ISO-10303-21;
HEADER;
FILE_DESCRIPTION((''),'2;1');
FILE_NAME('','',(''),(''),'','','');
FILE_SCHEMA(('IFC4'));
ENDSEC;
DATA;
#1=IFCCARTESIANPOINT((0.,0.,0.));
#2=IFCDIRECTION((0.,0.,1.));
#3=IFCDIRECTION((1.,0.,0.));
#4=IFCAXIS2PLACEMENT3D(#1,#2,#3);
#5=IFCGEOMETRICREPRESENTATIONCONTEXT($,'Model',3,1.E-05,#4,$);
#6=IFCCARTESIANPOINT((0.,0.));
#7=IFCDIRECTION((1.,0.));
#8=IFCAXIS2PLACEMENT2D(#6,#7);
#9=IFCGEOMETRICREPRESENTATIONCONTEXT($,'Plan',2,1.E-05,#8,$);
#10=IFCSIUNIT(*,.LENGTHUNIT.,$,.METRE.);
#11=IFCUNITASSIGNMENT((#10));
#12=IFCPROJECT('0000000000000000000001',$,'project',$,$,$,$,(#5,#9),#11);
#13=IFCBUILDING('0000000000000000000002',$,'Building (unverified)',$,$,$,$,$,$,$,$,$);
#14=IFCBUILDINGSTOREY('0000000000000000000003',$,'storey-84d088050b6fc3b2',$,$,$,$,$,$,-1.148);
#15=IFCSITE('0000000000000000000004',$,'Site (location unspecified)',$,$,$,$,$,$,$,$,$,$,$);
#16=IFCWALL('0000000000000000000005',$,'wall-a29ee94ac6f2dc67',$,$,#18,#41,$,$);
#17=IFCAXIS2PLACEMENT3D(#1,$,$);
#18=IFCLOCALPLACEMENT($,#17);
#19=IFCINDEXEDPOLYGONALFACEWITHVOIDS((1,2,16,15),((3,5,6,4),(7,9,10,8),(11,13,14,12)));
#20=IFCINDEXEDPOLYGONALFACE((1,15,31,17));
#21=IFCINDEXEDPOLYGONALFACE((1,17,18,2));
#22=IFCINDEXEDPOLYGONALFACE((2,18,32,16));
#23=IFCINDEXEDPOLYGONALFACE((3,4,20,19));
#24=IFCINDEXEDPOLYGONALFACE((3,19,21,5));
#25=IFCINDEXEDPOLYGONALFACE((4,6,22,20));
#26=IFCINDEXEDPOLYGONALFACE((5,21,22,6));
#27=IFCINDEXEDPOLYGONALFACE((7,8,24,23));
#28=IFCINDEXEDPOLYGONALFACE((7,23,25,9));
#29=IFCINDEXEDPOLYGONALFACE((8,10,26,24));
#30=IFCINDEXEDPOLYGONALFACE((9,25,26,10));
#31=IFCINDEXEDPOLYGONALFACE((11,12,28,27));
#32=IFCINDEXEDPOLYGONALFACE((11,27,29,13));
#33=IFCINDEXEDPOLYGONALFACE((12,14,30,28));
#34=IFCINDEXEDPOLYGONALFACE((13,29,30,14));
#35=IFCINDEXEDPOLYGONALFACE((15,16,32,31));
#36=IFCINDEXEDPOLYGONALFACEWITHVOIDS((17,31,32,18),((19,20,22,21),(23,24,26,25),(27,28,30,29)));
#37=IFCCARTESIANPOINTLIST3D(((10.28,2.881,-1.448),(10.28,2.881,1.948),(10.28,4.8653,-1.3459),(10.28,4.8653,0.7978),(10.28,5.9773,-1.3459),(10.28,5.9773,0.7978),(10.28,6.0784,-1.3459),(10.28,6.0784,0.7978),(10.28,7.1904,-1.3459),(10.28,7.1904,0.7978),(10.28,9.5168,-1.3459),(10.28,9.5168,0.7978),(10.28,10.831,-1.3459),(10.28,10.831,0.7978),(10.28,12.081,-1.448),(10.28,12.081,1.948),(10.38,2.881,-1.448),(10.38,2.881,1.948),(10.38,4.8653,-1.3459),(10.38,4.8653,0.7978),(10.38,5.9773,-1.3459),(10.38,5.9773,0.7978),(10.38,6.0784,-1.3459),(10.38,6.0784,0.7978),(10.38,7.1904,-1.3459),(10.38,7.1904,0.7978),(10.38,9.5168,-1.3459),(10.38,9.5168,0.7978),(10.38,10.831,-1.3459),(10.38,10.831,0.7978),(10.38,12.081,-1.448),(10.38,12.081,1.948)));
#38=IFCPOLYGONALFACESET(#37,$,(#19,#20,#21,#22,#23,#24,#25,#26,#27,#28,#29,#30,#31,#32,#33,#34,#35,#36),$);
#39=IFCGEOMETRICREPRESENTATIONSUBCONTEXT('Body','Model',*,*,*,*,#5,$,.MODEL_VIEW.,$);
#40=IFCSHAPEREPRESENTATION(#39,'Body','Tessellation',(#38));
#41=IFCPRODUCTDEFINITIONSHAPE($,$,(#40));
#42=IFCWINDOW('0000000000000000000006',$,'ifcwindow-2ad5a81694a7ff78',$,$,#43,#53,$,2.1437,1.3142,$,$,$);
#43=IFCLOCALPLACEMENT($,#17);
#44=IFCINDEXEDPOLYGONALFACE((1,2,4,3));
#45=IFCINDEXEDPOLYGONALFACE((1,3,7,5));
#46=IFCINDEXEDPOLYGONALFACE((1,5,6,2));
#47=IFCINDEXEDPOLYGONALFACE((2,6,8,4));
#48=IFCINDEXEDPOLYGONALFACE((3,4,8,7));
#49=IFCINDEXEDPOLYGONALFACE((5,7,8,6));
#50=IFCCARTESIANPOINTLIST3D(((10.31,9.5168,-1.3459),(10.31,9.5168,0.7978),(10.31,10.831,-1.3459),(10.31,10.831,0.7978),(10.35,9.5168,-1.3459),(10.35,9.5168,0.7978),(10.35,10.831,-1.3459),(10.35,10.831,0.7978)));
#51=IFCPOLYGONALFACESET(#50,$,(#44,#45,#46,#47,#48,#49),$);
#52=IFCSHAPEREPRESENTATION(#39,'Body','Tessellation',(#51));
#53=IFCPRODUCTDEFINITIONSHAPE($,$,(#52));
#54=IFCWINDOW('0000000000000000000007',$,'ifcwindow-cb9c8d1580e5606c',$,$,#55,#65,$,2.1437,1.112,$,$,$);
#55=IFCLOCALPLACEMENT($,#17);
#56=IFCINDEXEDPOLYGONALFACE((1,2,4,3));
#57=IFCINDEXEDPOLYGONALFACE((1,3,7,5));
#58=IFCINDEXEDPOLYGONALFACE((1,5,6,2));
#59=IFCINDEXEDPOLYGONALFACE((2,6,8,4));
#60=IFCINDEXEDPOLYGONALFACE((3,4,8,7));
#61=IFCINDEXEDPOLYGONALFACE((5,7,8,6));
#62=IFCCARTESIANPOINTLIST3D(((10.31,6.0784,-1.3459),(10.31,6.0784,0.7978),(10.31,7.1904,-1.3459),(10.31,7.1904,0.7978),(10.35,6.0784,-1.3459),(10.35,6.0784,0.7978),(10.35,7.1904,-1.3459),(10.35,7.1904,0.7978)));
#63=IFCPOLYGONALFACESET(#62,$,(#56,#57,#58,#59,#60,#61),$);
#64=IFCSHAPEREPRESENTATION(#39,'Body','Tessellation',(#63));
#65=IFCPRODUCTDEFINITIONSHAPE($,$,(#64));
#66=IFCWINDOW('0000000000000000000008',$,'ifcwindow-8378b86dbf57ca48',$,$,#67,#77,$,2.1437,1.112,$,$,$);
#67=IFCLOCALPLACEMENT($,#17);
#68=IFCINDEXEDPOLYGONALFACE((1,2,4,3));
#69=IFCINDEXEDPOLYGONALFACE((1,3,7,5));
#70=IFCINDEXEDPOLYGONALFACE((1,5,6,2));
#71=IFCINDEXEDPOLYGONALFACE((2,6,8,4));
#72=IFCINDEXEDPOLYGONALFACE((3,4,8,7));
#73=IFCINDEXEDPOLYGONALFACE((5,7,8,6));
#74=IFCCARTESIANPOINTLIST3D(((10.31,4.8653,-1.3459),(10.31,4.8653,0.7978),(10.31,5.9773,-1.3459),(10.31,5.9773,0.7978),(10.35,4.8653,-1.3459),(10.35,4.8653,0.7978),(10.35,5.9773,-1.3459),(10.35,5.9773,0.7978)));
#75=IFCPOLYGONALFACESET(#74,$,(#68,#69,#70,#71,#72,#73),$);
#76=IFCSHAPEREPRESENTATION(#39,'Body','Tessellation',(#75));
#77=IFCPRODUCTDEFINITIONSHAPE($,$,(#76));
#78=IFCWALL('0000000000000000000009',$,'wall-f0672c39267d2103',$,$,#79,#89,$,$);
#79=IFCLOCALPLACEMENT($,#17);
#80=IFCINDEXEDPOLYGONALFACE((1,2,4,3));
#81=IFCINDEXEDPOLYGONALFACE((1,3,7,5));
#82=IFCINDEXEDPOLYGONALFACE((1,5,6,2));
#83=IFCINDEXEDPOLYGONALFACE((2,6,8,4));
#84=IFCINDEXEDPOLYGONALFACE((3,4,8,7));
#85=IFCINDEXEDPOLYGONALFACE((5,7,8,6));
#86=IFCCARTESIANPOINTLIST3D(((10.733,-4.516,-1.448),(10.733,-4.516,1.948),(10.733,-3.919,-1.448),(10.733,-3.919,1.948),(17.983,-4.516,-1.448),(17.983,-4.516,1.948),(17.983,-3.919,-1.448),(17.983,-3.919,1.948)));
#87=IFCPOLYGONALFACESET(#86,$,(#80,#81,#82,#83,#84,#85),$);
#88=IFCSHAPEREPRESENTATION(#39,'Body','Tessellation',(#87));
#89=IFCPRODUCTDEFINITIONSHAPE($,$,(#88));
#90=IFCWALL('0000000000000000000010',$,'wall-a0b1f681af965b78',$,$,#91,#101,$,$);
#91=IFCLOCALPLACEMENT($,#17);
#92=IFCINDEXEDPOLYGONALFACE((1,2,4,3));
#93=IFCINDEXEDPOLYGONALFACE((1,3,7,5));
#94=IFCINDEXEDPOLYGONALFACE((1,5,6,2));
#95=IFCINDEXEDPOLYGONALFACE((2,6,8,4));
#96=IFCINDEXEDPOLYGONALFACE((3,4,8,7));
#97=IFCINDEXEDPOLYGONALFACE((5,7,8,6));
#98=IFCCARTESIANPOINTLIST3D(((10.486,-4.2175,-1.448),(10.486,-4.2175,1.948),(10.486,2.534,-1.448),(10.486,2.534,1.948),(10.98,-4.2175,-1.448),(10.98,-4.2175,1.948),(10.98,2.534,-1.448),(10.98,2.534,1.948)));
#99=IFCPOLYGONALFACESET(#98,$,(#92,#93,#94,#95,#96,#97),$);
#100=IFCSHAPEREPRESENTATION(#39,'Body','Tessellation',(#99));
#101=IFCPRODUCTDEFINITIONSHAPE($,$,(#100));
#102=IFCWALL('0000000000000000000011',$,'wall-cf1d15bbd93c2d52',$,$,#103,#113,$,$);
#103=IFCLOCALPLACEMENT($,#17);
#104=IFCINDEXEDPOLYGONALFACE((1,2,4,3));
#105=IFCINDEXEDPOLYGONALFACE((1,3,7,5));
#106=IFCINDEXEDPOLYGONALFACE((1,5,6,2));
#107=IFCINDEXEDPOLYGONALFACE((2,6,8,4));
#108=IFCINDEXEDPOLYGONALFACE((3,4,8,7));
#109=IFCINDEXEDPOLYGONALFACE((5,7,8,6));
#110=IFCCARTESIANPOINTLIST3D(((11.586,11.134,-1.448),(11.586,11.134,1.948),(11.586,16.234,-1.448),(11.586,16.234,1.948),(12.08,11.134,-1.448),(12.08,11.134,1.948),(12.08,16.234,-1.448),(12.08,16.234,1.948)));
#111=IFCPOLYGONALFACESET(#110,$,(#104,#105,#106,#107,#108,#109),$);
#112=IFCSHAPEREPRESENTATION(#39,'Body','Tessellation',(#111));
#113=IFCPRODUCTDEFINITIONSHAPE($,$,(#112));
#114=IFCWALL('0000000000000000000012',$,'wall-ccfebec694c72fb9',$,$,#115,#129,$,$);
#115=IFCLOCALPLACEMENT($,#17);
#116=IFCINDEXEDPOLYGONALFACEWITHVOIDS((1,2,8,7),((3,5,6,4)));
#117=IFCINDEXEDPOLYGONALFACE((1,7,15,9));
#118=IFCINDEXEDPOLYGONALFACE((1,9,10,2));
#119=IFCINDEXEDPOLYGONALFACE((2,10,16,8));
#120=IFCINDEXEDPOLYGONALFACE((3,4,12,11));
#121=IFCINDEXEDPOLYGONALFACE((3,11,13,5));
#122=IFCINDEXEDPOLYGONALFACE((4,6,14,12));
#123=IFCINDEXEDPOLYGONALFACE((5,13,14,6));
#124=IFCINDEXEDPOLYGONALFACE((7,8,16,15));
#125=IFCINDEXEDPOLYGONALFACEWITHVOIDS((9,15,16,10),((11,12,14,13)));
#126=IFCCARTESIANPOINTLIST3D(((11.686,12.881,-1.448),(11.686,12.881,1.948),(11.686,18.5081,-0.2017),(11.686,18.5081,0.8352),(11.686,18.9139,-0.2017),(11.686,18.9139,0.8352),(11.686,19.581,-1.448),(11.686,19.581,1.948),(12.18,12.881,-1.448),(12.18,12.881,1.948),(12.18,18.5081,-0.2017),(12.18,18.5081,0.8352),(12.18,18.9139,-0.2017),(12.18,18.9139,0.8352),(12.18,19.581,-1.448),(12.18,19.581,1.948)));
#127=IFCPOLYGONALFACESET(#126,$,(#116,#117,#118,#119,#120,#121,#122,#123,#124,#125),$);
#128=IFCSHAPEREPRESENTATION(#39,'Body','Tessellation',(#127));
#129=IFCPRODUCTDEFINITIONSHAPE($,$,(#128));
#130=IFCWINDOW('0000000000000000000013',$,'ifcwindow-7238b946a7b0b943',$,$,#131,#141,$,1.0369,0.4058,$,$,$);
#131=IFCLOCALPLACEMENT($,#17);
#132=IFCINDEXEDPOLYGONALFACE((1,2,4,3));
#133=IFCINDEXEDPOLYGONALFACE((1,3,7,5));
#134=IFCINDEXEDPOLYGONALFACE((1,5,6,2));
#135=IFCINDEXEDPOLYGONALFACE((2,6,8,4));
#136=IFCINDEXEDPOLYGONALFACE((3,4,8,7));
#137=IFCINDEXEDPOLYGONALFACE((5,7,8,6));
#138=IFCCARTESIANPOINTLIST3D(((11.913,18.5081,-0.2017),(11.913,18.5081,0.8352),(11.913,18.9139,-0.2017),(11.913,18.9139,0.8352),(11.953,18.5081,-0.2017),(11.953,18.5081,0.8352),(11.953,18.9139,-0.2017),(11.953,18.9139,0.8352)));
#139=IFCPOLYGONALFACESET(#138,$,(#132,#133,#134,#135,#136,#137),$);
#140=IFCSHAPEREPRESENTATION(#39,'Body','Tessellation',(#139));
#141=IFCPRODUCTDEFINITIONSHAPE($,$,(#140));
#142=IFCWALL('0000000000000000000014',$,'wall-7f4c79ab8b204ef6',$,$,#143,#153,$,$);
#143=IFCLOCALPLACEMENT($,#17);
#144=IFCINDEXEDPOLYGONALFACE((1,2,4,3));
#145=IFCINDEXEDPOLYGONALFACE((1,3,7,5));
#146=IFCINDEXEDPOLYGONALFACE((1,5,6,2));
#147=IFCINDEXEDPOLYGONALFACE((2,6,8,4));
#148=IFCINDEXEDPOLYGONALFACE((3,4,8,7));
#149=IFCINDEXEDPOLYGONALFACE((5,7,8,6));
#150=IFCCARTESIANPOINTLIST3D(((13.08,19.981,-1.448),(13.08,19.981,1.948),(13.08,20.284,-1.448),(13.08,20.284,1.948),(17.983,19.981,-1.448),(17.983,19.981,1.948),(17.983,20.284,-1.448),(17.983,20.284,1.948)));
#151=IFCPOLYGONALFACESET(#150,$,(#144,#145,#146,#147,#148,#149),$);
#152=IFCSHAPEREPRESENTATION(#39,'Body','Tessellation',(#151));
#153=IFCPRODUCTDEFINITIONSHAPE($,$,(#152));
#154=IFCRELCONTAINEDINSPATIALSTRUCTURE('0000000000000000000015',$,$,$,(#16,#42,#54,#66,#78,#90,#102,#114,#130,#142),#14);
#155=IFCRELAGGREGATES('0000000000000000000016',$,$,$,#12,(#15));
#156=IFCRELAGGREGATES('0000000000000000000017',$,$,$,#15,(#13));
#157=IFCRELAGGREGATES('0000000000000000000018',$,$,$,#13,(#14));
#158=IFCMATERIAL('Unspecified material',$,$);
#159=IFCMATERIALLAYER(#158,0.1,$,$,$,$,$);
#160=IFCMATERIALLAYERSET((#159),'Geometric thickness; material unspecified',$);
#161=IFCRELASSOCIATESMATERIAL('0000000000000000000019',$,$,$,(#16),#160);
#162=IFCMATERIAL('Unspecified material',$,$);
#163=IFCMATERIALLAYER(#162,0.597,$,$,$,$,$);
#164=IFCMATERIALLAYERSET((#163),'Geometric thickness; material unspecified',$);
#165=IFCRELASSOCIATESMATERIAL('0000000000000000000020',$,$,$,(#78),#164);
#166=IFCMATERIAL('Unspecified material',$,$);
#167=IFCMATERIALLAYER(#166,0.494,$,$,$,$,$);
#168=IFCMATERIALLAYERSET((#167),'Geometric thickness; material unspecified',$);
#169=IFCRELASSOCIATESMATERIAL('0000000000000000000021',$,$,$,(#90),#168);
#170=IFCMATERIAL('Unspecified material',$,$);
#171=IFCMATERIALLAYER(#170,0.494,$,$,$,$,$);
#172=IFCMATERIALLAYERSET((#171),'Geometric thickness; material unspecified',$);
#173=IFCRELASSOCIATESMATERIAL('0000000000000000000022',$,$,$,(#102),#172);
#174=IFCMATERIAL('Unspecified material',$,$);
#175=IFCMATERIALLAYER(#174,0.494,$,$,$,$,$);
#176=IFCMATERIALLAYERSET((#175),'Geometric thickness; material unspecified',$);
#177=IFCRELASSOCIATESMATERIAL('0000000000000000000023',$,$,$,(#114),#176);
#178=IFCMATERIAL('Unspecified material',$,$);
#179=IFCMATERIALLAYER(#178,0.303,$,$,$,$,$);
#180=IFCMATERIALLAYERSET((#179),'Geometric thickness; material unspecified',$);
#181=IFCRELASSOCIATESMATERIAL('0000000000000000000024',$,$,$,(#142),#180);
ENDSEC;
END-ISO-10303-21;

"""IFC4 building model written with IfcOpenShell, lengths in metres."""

from ifc_helpers import new_model, si_unit, frame, origin_with_axes, origin_2d_with_axis, place, context, subcontext, project, spatial, indexed_curve, outline, extrude, material, layer, layer_set, layer_usage, element, fill, save


model = new_model("IFC4")

# Units and contexts
model_context = context("Model", 3, precision=1e-05, world=origin_with_axes())
plan_context = context("Plan", 2, precision=1e-05, world=origin_2d_with_axis())
body_context = subcontext(model_context, "Body", "Model", "MODEL_VIEW")
ifc_project = project(units=[si_unit("LENGTHUNIT", "METRE")], contexts=[model_context, plan_context])

# Site, building, storey
site = spatial("IfcSite", under=ifc_project, Name="Site (location unspecified)")
building = spatial("IfcBuilding", under=site, Name="Building (unverified)")
storey = spatial("IfcBuildingStorey", under=building, Name="storey-84d088050b6fc3b2", Elevation=-1.148)

# Wall, openings, windows
ifc_material_1 = material(Name="Unspecified material")
ifc_layer_1 = layer(ifc_material_1, 0.1)
ifc_layer_set_1 = layer_set([ifc_layer_1], Name="Geometric thickness; material unspecified")
ifc_layer_usage_1 = layer_usage(ifc_layer_set_1, "AXIS2", "POSITIVE", -0.05)
wall_1_placement = place(None, frame((10.33, 12.081, -1.448), z_axis=(0.0, 0.0, 1.0), x_axis=(0.0, -1.0, 0.0)))
wall_1 = element("IfcWall", 1, at=wall_1_placement, inside=storey, material=ifc_layer_usage_1, Name="wall-a29ee94ac6f2dc67", context=body_context, shape_type="SweptSolid", body=[
    extrude(outline(indexed_curve([(0.0, 0.0), (0.0, 0.1), (9.2, 0.1), (9.2, 0.0), (0.0, 0.0)], self_intersect=False)), frame((0.0, -0.05, 0.0), z_axis=(0.0, 0.0, 1.0), x_axis=(1.0, 0.0, 0.0)), (0.0, 0.0, 1.0), 3.396),
])
opening_1_placement = place(wall_1_placement, frame((1.25, -0.06, 0.1021), z_axis=(0.0, 0.0, 1.0), x_axis=(1.0, 0.0, 0.0)))
opening_1 = element("IfcOpeningElement", 2, at=opening_1_placement, cuts=wall_1, context=body_context, shape_type="SweptSolid", body=[
    extrude(outline(indexed_curve([(0.0, 0.0), (0.0, 0.12), (1.3142, 0.12), (1.3142, 0.0), (0.0, 0.0)], self_intersect=False)), origin_with_axes(), (0.0, 0.0, 1.0), 2.1437),
])
opening_2_placement = place(wall_1_placement, frame((4.8906, -0.06, 0.1021), z_axis=(0.0, 0.0, 1.0), x_axis=(1.0, 0.0, 0.0)))
opening_2 = element("IfcOpeningElement", 3, at=opening_2_placement, cuts=wall_1, context=body_context, shape_type="SweptSolid", body=[
    extrude(outline(indexed_curve([(0.0, 0.0), (0.0, 0.12), (1.112, 0.12), (1.112, 0.0), (0.0, 0.0)], self_intersect=False)), origin_with_axes(), (0.0, 0.0, 1.0), 2.1437),
])
opening_3_placement = place(wall_1_placement, frame((6.1037, -0.06, 0.1021), z_axis=(0.0, 0.0, 1.0), x_axis=(1.0, 0.0, 0.0)))
opening_3 = element("IfcOpeningElement", 4, at=opening_3_placement, cuts=wall_1, context=body_context, shape_type="SweptSolid", body=[
    extrude(outline(indexed_curve([(0.0, 0.0), (0.0, 0.12), (1.112, 0.12), (1.112, 0.0), (0.0, 0.0)], self_intersect=False)), origin_with_axes(), (0.0, 0.0, 1.0), 2.1437),
])
window_1_placement = place(None, frame((10.31, 10.831, -1.3459), z_axis=(0.0, 0.0, 1.0), x_axis=(0.0, -1.0, 0.0)))
window_1 = element("IfcWindow", 5, at=window_1_placement, inside=storey, Name="ifcwindow-2ad5a81694a7ff78", OverallHeight=2.1437, OverallWidth=1.3142, context=body_context, shape_type="SweptSolid", body=[
    extrude(outline(indexed_curve([(0.0, 0.0), (0.0, 0.04), (1.3142, 0.04), (1.3142, 0.0), (0.0, 0.0)], self_intersect=False)), origin_with_axes(), (0.0, 0.0, 1.0), 2.1437),
])
fill(opening_1, window_1)
window_2_placement = place(None, frame((10.31, 7.1904, -1.3459), z_axis=(0.0, 0.0, 1.0), x_axis=(0.0, -1.0, 0.0)))
window_2 = element("IfcWindow", 6, at=window_2_placement, inside=storey, Name="ifcwindow-cb9c8d1580e5606c", OverallHeight=2.1437, OverallWidth=1.112, context=body_context, shape_type="SweptSolid", body=[
    extrude(outline(indexed_curve([(0.0, 0.0), (0.0, 0.04), (1.112, 0.04), (1.112, 0.0), (0.0, 0.0)], self_intersect=False)), origin_with_axes(), (0.0, 0.0, 1.0), 2.1437),
])
fill(opening_2, window_2)
window_3_placement = place(None, frame((10.31, 5.9773, -1.3459), z_axis=(0.0, 0.0, 1.0), x_axis=(0.0, -1.0, 0.0)))
window_3 = element("IfcWindow", 7, at=window_3_placement, inside=storey, Name="ifcwindow-8378b86dbf57ca48", OverallHeight=2.1437, OverallWidth=1.112, context=body_context, shape_type="SweptSolid", body=[
    extrude(outline(indexed_curve([(0.0, 0.0), (0.0, 0.04), (1.112, 0.04), (1.112, 0.0), (0.0, 0.0)], self_intersect=False)), origin_with_axes(), (0.0, 0.0, 1.0), 2.1437),
])
fill(opening_3, window_3)

# Walls
ifc_material_2 = material(Name="Unspecified material")
ifc_layer_2 = layer(ifc_material_2, 0.597)
ifc_layer_set_2 = layer_set([ifc_layer_2], Name="Geometric thickness; material unspecified")
ifc_layer_usage_2 = layer_usage(ifc_layer_set_2, "AXIS2", "POSITIVE", -0.2985)
wall_2_placement = place(None, frame((17.983, -4.2175, -1.448), z_axis=(0.0, 0.0, 1.0), x_axis=(-1.0, 0.0, 0.0)))
element("IfcWall", 8, at=wall_2_placement, inside=storey, material=ifc_layer_usage_2, Name="wall-f0672c39267d2103", context=body_context, shape_type="SweptSolid", body=[
    extrude(outline(indexed_curve([(0.0, 0.0), (0.0, 0.597), (7.25, 0.597), (7.25, 0.0), (0.0, 0.0)], self_intersect=False)), frame((0.0, -0.2985, 0.0), z_axis=(0.0, 0.0, 1.0), x_axis=(1.0, 0.0, 0.0)), (0.0, 0.0, 1.0), 3.396),
])
ifc_material_3 = material(Name="Unspecified material")
ifc_layer_3 = layer(ifc_material_3, 0.494)
ifc_layer_set_3 = layer_set([ifc_layer_3], Name="Geometric thickness; material unspecified")
ifc_layer_usage_3 = layer_usage(ifc_layer_set_3, "AXIS2", "POSITIVE", -0.247)
wall_3_placement = place(None, frame((10.733, -4.2175, -1.448), z_axis=(0.0, 0.0, 1.0), x_axis=(0.0, 1.0, 0.0)))
element("IfcWall", 9, at=wall_3_placement, inside=storey, material=ifc_layer_usage_3, Name="wall-a0b1f681af965b78", context=body_context, shape_type="SweptSolid", body=[
    extrude(outline(indexed_curve([(0.0, 0.0), (0.0, 0.494), (6.7515, 0.494), (6.7515, 0.0), (0.0, 0.0)], self_intersect=False)), frame((0.0, -0.247, 0.0), z_axis=(0.0, 0.0, 1.0), x_axis=(1.0, 0.0, 0.0)), (0.0, 0.0, 1.0), 3.396),
])
ifc_material_4 = material(Name="Unspecified material")
ifc_layer_4 = layer(ifc_material_4, 0.494)
ifc_layer_set_4 = layer_set([ifc_layer_4], Name="Geometric thickness; material unspecified")
ifc_layer_usage_4 = layer_usage(ifc_layer_set_4, "AXIS2", "POSITIVE", -0.247)
wall_4_placement = place(None, frame((11.833, 11.134, -1.448), z_axis=(0.0, 0.0, 1.0), x_axis=(0.0, 1.0, 0.0)))
element("IfcWall", 10, at=wall_4_placement, inside=storey, material=ifc_layer_usage_4, Name="wall-cf1d15bbd93c2d52", context=body_context, shape_type="SweptSolid", body=[
    extrude(outline(indexed_curve([(0.0, 0.0), (0.0, 0.494), (5.1, 0.494), (5.1, 0.0), (0.0, 0.0)], self_intersect=False)), frame((0.0, -0.247, 0.0), z_axis=(0.0, 0.0, 1.0), x_axis=(1.0, 0.0, 0.0)), (0.0, 0.0, 1.0), 3.396),
])

# Wall, opening, window
ifc_material_5 = material(Name="Unspecified material")
ifc_layer_5 = layer(ifc_material_5, 0.494)
ifc_layer_set_5 = layer_set([ifc_layer_5], Name="Geometric thickness; material unspecified")
ifc_layer_usage_5 = layer_usage(ifc_layer_set_5, "AXIS2", "POSITIVE", -0.247)
wall_5_placement = place(None, frame((11.933, 12.881, -1.448), z_axis=(0.0, 0.0, 1.0), x_axis=(0.0, 1.0, 0.0)))
wall_5 = element("IfcWall", 11, at=wall_5_placement, inside=storey, material=ifc_layer_usage_5, Name="wall-ccfebec694c72fb9", context=body_context, shape_type="SweptSolid", body=[
    extrude(outline(indexed_curve([(0.0, 0.0), (0.0, 0.494), (6.7, 0.494), (6.7, 0.0), (0.0, 0.0)], self_intersect=False)), frame((0.0, -0.247, 0.0), z_axis=(0.0, 0.0, 1.0), x_axis=(1.0, 0.0, 0.0)), (0.0, 0.0, 1.0), 3.396),
])
opening_4_placement = place(wall_5_placement, frame((5.6271, -0.257, 1.2463), z_axis=(0.0, 0.0, 1.0), x_axis=(1.0, 0.0, 0.0)))
opening_4 = element("IfcOpeningElement", 12, at=opening_4_placement, cuts=wall_5, context=body_context, shape_type="SweptSolid", body=[
    extrude(outline(indexed_curve([(0.0, 0.0), (0.0, 0.514), (0.4058, 0.514), (0.4058, 0.0), (0.0, 0.0)], self_intersect=False)), origin_with_axes(), (0.0, 0.0, 1.0), 1.0369),
])
window_4_placement = place(None, frame((11.953, 18.5081, -0.2017), z_axis=(0.0, 0.0, 1.0), x_axis=(0.0, 1.0, 0.0)))
window_4 = element("IfcWindow", 13, at=window_4_placement, inside=storey, Name="ifcwindow-7238b946a7b0b943", OverallHeight=1.0369, OverallWidth=0.4058, context=body_context, shape_type="SweptSolid", body=[
    extrude(outline(indexed_curve([(0.0, 0.0), (0.0, 0.04), (0.4058, 0.04), (0.4058, 0.0), (0.0, 0.0)], self_intersect=False)), origin_with_axes(), (0.0, 0.0, 1.0), 1.0369),
])
fill(opening_4, window_4)

# Wall
ifc_material_6 = material(Name="Unspecified material")
ifc_layer_6 = layer(ifc_material_6, 0.303)
ifc_layer_set_6 = layer_set([ifc_layer_6], Name="Geometric thickness; material unspecified")
ifc_layer_usage_6 = layer_usage(ifc_layer_set_6, "AXIS2", "POSITIVE", -0.1515)
wall_6_placement = place(None, frame((13.08, 20.1325, -1.448), z_axis=(0.0, 0.0, 1.0), x_axis=(1.0, 0.0, 0.0)))
element("IfcWall", 14, at=wall_6_placement, inside=storey, material=ifc_layer_usage_6, Name="wall-7f4c79ab8b204ef6", context=body_context, shape_type="SweptSolid", body=[
    extrude(outline(indexed_curve([(0.0, 0.0), (0.0, 0.303), (4.903, 0.303), (4.903, 0.0), (0.0, 0.0)], self_intersect=False)), frame((0.0, -0.1515, 0.0), z_axis=(0.0, 0.0, 1.0), x_axis=(1.0, 0.0, 0.0)), (0.0, 0.0, 1.0), 3.396),
])

save(model, "model.ifc")
